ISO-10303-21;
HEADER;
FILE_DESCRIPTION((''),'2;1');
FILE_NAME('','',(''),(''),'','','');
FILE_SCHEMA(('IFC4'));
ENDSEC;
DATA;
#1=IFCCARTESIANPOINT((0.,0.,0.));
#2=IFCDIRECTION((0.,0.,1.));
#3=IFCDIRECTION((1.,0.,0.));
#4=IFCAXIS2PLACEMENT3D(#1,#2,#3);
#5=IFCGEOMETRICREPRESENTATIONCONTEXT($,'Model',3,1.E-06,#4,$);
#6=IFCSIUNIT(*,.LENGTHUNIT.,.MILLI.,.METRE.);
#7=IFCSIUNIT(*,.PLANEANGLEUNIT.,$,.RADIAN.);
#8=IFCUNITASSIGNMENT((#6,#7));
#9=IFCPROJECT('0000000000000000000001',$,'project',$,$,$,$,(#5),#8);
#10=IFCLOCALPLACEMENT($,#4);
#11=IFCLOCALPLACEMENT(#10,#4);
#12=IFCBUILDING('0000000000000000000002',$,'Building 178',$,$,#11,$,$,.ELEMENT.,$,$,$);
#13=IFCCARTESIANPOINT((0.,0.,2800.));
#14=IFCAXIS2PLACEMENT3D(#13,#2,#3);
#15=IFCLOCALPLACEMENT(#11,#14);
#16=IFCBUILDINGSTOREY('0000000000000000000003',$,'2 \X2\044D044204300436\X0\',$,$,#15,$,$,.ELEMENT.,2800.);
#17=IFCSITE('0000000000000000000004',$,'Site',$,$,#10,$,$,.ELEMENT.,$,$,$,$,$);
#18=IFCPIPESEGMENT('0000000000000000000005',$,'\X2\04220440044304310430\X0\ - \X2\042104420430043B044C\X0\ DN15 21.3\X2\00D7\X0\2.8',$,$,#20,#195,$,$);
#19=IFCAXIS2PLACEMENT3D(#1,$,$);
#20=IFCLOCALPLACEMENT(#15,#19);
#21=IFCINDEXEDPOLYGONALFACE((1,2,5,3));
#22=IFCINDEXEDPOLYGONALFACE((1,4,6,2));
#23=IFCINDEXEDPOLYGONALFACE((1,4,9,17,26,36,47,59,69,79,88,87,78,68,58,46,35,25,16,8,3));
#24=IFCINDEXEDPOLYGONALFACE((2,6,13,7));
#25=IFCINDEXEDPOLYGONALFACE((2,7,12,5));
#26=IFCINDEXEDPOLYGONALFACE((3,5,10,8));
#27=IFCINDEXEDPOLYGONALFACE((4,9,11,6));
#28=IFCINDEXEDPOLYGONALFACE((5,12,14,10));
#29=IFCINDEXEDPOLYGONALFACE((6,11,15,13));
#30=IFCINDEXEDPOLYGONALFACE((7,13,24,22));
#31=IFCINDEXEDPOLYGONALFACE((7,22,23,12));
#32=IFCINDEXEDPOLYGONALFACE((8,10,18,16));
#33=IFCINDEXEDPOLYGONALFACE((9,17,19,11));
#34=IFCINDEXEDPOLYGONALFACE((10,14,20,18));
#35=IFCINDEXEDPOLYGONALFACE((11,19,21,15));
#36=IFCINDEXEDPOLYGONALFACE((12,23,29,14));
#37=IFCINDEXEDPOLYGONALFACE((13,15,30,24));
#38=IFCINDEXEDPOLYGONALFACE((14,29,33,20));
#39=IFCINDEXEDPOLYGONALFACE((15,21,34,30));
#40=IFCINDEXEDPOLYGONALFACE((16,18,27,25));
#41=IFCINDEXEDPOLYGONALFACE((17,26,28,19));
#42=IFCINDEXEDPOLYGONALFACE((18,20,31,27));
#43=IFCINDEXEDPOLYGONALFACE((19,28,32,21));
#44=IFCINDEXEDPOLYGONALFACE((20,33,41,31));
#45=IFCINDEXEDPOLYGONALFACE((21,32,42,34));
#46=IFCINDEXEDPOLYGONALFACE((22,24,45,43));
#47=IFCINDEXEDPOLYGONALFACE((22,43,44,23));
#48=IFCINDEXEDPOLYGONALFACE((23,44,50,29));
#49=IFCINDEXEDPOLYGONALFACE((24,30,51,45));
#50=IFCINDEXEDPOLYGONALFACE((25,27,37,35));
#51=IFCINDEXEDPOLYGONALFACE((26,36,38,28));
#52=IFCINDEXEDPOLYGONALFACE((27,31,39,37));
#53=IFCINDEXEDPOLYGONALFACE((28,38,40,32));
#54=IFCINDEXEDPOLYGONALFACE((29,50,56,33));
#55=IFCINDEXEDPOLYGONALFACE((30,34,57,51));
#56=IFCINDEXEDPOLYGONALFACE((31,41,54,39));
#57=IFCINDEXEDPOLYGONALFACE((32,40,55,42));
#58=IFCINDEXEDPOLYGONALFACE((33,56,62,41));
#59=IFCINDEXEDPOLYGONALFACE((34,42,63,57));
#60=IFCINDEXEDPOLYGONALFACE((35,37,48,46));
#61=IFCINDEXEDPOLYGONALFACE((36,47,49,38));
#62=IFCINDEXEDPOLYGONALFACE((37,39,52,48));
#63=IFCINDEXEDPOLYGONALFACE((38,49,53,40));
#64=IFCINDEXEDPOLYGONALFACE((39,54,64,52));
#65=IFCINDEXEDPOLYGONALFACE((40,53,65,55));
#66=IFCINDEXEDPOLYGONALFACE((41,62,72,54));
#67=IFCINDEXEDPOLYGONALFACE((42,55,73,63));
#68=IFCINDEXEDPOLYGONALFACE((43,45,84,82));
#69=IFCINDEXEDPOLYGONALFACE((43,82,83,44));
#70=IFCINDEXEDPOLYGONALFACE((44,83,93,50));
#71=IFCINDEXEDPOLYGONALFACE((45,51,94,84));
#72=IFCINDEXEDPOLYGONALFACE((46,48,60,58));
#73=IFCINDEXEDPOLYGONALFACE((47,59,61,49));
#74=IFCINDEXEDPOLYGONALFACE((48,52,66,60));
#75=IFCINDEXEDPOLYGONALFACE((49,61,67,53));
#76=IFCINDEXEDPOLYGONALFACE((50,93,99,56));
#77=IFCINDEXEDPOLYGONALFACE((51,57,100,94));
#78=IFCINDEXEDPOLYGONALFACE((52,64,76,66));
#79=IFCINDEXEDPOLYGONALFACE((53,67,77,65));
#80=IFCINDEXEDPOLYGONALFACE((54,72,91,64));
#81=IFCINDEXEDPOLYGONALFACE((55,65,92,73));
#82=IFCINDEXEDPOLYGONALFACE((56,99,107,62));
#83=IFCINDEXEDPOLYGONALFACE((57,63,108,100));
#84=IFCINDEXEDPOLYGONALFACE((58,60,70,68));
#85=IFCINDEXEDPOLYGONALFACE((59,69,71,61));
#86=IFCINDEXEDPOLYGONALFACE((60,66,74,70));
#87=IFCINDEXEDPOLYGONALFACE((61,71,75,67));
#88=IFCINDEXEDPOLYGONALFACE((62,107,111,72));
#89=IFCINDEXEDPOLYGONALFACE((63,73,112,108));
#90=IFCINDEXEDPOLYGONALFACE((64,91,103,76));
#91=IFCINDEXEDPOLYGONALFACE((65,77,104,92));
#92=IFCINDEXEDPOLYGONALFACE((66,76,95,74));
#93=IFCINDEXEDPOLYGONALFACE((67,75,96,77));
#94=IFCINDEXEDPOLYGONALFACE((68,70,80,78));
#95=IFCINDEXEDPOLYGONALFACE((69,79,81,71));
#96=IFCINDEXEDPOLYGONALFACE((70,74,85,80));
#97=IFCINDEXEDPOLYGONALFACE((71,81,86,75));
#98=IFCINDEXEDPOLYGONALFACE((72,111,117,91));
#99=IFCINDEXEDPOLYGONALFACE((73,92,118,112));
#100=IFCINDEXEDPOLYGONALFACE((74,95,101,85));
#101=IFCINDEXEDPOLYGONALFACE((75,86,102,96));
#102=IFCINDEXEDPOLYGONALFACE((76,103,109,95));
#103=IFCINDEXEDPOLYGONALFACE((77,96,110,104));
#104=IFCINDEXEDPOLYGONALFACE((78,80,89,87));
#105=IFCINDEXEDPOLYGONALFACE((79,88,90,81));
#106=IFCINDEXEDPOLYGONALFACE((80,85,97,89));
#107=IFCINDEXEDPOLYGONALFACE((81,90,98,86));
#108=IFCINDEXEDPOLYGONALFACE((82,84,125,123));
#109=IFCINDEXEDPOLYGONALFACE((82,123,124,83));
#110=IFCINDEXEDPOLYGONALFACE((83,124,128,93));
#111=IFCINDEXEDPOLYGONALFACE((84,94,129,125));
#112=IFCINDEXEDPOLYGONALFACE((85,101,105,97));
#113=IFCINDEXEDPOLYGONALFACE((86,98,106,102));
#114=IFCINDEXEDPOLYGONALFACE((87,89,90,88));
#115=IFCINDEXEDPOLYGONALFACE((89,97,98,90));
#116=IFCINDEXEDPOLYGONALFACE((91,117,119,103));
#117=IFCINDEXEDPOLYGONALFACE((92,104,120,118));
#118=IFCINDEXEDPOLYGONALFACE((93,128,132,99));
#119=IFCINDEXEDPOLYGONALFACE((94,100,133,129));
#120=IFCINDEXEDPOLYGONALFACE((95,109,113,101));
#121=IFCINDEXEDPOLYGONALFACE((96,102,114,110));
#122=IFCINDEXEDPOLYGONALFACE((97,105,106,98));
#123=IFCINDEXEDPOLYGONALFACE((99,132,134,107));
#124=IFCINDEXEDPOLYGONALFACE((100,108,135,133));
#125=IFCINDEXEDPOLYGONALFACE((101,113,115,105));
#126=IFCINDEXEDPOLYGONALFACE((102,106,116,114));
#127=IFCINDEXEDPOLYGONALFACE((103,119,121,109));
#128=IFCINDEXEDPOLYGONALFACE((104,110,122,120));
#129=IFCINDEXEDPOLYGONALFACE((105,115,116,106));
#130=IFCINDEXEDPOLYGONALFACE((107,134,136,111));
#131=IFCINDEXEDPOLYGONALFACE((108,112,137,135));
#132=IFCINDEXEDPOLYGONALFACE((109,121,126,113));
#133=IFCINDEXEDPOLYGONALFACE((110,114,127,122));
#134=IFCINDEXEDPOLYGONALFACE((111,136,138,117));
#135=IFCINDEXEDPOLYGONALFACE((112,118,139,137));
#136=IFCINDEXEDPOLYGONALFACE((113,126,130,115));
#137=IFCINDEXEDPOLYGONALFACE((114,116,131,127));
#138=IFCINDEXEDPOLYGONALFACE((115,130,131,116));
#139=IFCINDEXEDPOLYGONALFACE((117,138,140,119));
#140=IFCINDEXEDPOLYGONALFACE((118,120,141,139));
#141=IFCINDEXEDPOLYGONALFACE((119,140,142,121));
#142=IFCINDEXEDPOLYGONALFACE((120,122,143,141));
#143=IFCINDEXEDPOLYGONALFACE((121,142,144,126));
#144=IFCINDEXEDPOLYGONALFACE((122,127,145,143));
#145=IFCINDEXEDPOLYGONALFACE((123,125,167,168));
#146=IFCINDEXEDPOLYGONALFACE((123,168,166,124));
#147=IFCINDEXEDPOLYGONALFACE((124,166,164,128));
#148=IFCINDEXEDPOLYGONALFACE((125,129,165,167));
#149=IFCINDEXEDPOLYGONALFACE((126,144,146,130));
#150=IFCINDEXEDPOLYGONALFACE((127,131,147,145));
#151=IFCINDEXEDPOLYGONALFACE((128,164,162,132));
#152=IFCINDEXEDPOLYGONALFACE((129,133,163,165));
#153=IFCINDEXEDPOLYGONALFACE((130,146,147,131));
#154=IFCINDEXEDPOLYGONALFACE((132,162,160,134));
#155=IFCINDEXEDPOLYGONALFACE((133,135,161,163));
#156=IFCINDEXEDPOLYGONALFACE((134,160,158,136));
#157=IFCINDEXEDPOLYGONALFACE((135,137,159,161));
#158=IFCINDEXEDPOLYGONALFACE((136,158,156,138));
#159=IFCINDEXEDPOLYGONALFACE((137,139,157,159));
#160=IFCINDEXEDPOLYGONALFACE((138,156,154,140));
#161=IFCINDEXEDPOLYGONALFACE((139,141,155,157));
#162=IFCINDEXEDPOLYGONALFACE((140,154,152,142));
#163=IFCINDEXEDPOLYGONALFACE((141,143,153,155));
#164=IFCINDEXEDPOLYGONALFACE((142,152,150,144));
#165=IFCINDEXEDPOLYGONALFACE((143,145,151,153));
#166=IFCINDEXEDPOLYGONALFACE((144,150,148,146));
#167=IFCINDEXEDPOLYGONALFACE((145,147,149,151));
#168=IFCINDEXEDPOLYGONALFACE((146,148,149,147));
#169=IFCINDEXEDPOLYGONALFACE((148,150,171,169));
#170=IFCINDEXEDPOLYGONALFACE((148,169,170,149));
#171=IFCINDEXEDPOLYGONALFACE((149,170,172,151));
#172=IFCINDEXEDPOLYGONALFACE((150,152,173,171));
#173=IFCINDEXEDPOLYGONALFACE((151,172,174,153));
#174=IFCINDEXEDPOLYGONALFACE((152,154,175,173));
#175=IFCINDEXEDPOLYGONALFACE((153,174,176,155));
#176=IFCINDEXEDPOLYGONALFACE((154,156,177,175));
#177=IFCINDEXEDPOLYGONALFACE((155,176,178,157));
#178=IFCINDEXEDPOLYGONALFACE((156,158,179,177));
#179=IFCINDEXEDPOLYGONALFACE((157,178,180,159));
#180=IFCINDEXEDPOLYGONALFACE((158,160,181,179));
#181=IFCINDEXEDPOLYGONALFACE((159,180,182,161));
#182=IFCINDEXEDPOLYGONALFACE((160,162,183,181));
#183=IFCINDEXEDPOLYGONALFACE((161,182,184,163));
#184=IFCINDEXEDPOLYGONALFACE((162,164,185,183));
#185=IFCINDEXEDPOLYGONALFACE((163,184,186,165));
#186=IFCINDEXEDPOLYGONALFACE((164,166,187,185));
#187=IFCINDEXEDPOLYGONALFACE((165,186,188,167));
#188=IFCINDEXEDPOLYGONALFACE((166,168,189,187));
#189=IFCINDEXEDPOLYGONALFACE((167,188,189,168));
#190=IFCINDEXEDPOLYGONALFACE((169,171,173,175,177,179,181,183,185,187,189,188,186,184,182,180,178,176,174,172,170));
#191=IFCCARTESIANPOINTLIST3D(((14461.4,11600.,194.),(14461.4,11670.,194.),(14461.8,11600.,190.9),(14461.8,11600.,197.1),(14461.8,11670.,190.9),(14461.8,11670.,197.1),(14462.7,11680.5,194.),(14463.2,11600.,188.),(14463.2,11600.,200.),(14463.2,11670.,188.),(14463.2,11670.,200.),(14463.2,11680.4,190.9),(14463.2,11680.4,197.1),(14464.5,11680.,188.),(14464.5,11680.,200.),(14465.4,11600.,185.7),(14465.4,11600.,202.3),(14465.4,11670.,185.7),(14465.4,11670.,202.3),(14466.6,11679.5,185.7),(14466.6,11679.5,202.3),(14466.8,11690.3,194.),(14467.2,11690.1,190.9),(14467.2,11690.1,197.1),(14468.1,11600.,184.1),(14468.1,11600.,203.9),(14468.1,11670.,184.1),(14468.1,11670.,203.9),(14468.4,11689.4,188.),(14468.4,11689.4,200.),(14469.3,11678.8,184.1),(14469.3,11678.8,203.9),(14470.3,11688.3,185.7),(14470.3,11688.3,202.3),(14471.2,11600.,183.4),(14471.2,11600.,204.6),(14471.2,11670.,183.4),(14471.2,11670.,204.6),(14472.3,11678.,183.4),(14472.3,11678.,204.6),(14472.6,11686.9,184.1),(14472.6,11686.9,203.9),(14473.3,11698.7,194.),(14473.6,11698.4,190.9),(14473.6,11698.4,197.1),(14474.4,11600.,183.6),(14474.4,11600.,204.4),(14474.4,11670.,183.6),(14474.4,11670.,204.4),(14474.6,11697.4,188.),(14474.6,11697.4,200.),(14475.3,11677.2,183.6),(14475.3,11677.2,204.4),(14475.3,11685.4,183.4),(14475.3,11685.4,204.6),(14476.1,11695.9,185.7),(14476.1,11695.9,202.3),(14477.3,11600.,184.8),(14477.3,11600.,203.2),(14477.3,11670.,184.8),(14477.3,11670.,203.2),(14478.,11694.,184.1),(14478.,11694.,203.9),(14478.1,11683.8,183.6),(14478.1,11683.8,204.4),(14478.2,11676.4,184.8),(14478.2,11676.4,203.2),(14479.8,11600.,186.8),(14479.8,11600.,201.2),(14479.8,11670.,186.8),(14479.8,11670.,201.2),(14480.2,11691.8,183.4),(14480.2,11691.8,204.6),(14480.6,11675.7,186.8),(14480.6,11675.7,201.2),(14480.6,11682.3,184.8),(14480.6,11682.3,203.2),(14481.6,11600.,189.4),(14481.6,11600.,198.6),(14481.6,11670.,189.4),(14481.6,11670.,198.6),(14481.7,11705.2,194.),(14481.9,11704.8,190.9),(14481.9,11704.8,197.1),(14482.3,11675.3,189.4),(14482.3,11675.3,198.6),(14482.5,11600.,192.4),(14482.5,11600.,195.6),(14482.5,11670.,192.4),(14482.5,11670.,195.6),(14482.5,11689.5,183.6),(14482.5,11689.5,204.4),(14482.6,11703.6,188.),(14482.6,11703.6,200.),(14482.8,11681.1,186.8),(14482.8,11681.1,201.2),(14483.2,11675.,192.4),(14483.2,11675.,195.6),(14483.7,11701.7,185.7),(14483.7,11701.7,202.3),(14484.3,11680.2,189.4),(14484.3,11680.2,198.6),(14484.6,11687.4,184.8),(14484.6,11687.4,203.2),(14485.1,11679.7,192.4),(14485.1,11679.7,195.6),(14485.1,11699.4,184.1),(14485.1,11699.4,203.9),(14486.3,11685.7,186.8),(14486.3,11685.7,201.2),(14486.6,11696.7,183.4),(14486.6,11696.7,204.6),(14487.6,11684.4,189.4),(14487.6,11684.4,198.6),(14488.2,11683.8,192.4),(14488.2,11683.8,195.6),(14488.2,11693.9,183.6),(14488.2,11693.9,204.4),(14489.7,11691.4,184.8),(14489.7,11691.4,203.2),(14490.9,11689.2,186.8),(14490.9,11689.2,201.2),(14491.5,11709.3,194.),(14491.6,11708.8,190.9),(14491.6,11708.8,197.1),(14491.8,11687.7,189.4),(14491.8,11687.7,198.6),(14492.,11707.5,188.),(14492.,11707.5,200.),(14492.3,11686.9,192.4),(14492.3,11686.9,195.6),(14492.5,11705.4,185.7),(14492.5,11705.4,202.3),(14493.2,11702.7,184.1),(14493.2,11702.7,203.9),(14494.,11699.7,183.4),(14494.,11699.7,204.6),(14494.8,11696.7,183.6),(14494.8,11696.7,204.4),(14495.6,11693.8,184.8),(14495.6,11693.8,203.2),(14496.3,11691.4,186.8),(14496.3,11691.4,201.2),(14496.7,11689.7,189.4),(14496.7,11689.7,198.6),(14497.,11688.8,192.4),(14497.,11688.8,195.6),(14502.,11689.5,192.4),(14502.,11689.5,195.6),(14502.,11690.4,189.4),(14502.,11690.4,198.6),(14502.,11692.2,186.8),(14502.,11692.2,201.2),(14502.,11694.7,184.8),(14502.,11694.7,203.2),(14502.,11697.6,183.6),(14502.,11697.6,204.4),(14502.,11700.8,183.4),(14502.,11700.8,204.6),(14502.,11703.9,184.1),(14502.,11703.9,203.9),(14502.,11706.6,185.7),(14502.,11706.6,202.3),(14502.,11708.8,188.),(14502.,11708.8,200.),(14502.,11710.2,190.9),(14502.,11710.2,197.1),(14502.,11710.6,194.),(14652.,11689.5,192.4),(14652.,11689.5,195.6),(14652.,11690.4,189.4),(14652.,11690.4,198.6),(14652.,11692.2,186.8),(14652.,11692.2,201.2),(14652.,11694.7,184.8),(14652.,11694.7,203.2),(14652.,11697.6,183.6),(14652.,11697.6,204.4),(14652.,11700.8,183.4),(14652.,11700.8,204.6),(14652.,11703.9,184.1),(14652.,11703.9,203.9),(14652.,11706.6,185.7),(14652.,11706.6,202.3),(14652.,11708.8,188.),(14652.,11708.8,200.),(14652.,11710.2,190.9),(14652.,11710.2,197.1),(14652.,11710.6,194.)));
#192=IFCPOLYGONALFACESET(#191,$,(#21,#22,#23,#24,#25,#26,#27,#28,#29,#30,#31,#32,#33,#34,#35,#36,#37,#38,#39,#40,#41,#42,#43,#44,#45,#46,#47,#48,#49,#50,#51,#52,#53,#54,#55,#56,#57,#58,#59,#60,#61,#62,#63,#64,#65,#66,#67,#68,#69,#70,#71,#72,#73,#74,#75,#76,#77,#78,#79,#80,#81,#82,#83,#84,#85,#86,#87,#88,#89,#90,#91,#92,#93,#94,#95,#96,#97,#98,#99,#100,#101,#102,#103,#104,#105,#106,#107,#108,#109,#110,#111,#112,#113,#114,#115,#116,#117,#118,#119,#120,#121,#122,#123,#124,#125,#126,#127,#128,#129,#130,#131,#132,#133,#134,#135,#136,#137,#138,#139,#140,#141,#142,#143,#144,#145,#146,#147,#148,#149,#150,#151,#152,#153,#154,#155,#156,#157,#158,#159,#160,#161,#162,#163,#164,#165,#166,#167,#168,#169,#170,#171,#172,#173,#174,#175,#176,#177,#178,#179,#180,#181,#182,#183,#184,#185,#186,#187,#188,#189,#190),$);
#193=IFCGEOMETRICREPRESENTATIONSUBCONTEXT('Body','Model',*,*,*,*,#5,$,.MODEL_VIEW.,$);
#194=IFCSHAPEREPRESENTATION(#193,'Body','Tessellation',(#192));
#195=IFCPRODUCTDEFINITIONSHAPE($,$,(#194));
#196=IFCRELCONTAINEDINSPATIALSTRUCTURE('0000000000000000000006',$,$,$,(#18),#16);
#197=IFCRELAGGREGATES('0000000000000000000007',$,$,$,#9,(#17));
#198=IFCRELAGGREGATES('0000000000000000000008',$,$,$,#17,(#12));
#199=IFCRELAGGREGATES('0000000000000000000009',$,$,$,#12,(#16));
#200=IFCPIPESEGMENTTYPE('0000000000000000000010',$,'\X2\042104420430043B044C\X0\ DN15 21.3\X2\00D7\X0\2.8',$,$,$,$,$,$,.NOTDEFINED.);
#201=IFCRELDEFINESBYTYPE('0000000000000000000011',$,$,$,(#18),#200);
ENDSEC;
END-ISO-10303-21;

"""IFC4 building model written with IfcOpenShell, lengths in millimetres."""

from ifc_helpers import new_model, entity, si_unit, frame, origin_with_axes, place, context, subcontext, project, spatial, source, transform, mapped, type_object, element, save


model = new_model("IFC4")

# Units and contexts
model_context = context("Model", 3, precision=1e-06, world=origin_with_axes())
body_context = subcontext(model_context, "Body", "Model", "MODEL_VIEW")
ifc_project = project(units=[si_unit("LENGTHUNIT", "METRE", prefix="MILLI"), si_unit("PLANEANGLEUNIT", "RADIAN")], contexts=[model_context])

# Site, building, storey
site_placement = place(None, origin_with_axes())
site = spatial("IfcSite", under=ifc_project, at=site_placement, Name="Site", CompositionType="ELEMENT")
building_placement = place(site_placement, origin_with_axes())
building = spatial("IfcBuilding", under=site, at=building_placement, Name="Building 178", CompositionType="ELEMENT")
storey_placement = place(building_placement, frame((0.0, 0.0, 2800.0), z_axis=(0.0, 0.0, 1.0), x_axis=(1.0, 0.0, 0.0)))
storey = spatial("IfcBuildingStorey", under=building, at=storey_placement, Name="2 этаж", CompositionType="ELEMENT", Elevation=2800.0)

# Pipe segment
pipe_segment_type = type_object("IfcPipeSegmentType", Name="Сталь DN15 21.3×2.8", PredefinedType="NOTDEFINED")
shared_shape_1 = source(origin_with_axes(), body_context, "Body", "AdvancedSweptSolid", [
    entity("IfcSweptDiskSolid", entity("IfcIndexedPolyCurve", entity("IfcCartesianPointList3D", [[0.0, 0.0, 0.0], [0.0, 0.0, -70.0], [8.8, 0.0, -91.2], [30.0, 0.0, -100.0], [180.0, 0.0, -100.0]]), [entity("IfcLineIndex", [1, 2]), entity("IfcArcIndex", [2, 3, 4]), entity("IfcLineIndex", [4, 5])]), 10.7),
])
for number, where, z_axis, x_axis, name in (
    (1, (14472.0, 11600.0, 194.0), (0.0, -1.0, 0.0), (1.0, 0.0, 0.0), "Труба - Сталь DN15 21.3×2.8"),
):
    element("IfcPipeSegment", number, at=place(storey_placement, frame(where, z_axis=z_axis, x_axis=x_axis)), inside=storey, type_object=pipe_segment_type, Name=name, context=body_context, shape_type="MappedRepresentation", body=[
        mapped(shared_shape_1, transform((0.0, 0.0, 0.0), x_axis=(1.0, 0.0, 0.0), y_axis=(0.0, 1.0, 0.0), z_axis=(0.0, 0.0, 1.0), scale=1.0)),
    ])

save(model, "model.ifc")
